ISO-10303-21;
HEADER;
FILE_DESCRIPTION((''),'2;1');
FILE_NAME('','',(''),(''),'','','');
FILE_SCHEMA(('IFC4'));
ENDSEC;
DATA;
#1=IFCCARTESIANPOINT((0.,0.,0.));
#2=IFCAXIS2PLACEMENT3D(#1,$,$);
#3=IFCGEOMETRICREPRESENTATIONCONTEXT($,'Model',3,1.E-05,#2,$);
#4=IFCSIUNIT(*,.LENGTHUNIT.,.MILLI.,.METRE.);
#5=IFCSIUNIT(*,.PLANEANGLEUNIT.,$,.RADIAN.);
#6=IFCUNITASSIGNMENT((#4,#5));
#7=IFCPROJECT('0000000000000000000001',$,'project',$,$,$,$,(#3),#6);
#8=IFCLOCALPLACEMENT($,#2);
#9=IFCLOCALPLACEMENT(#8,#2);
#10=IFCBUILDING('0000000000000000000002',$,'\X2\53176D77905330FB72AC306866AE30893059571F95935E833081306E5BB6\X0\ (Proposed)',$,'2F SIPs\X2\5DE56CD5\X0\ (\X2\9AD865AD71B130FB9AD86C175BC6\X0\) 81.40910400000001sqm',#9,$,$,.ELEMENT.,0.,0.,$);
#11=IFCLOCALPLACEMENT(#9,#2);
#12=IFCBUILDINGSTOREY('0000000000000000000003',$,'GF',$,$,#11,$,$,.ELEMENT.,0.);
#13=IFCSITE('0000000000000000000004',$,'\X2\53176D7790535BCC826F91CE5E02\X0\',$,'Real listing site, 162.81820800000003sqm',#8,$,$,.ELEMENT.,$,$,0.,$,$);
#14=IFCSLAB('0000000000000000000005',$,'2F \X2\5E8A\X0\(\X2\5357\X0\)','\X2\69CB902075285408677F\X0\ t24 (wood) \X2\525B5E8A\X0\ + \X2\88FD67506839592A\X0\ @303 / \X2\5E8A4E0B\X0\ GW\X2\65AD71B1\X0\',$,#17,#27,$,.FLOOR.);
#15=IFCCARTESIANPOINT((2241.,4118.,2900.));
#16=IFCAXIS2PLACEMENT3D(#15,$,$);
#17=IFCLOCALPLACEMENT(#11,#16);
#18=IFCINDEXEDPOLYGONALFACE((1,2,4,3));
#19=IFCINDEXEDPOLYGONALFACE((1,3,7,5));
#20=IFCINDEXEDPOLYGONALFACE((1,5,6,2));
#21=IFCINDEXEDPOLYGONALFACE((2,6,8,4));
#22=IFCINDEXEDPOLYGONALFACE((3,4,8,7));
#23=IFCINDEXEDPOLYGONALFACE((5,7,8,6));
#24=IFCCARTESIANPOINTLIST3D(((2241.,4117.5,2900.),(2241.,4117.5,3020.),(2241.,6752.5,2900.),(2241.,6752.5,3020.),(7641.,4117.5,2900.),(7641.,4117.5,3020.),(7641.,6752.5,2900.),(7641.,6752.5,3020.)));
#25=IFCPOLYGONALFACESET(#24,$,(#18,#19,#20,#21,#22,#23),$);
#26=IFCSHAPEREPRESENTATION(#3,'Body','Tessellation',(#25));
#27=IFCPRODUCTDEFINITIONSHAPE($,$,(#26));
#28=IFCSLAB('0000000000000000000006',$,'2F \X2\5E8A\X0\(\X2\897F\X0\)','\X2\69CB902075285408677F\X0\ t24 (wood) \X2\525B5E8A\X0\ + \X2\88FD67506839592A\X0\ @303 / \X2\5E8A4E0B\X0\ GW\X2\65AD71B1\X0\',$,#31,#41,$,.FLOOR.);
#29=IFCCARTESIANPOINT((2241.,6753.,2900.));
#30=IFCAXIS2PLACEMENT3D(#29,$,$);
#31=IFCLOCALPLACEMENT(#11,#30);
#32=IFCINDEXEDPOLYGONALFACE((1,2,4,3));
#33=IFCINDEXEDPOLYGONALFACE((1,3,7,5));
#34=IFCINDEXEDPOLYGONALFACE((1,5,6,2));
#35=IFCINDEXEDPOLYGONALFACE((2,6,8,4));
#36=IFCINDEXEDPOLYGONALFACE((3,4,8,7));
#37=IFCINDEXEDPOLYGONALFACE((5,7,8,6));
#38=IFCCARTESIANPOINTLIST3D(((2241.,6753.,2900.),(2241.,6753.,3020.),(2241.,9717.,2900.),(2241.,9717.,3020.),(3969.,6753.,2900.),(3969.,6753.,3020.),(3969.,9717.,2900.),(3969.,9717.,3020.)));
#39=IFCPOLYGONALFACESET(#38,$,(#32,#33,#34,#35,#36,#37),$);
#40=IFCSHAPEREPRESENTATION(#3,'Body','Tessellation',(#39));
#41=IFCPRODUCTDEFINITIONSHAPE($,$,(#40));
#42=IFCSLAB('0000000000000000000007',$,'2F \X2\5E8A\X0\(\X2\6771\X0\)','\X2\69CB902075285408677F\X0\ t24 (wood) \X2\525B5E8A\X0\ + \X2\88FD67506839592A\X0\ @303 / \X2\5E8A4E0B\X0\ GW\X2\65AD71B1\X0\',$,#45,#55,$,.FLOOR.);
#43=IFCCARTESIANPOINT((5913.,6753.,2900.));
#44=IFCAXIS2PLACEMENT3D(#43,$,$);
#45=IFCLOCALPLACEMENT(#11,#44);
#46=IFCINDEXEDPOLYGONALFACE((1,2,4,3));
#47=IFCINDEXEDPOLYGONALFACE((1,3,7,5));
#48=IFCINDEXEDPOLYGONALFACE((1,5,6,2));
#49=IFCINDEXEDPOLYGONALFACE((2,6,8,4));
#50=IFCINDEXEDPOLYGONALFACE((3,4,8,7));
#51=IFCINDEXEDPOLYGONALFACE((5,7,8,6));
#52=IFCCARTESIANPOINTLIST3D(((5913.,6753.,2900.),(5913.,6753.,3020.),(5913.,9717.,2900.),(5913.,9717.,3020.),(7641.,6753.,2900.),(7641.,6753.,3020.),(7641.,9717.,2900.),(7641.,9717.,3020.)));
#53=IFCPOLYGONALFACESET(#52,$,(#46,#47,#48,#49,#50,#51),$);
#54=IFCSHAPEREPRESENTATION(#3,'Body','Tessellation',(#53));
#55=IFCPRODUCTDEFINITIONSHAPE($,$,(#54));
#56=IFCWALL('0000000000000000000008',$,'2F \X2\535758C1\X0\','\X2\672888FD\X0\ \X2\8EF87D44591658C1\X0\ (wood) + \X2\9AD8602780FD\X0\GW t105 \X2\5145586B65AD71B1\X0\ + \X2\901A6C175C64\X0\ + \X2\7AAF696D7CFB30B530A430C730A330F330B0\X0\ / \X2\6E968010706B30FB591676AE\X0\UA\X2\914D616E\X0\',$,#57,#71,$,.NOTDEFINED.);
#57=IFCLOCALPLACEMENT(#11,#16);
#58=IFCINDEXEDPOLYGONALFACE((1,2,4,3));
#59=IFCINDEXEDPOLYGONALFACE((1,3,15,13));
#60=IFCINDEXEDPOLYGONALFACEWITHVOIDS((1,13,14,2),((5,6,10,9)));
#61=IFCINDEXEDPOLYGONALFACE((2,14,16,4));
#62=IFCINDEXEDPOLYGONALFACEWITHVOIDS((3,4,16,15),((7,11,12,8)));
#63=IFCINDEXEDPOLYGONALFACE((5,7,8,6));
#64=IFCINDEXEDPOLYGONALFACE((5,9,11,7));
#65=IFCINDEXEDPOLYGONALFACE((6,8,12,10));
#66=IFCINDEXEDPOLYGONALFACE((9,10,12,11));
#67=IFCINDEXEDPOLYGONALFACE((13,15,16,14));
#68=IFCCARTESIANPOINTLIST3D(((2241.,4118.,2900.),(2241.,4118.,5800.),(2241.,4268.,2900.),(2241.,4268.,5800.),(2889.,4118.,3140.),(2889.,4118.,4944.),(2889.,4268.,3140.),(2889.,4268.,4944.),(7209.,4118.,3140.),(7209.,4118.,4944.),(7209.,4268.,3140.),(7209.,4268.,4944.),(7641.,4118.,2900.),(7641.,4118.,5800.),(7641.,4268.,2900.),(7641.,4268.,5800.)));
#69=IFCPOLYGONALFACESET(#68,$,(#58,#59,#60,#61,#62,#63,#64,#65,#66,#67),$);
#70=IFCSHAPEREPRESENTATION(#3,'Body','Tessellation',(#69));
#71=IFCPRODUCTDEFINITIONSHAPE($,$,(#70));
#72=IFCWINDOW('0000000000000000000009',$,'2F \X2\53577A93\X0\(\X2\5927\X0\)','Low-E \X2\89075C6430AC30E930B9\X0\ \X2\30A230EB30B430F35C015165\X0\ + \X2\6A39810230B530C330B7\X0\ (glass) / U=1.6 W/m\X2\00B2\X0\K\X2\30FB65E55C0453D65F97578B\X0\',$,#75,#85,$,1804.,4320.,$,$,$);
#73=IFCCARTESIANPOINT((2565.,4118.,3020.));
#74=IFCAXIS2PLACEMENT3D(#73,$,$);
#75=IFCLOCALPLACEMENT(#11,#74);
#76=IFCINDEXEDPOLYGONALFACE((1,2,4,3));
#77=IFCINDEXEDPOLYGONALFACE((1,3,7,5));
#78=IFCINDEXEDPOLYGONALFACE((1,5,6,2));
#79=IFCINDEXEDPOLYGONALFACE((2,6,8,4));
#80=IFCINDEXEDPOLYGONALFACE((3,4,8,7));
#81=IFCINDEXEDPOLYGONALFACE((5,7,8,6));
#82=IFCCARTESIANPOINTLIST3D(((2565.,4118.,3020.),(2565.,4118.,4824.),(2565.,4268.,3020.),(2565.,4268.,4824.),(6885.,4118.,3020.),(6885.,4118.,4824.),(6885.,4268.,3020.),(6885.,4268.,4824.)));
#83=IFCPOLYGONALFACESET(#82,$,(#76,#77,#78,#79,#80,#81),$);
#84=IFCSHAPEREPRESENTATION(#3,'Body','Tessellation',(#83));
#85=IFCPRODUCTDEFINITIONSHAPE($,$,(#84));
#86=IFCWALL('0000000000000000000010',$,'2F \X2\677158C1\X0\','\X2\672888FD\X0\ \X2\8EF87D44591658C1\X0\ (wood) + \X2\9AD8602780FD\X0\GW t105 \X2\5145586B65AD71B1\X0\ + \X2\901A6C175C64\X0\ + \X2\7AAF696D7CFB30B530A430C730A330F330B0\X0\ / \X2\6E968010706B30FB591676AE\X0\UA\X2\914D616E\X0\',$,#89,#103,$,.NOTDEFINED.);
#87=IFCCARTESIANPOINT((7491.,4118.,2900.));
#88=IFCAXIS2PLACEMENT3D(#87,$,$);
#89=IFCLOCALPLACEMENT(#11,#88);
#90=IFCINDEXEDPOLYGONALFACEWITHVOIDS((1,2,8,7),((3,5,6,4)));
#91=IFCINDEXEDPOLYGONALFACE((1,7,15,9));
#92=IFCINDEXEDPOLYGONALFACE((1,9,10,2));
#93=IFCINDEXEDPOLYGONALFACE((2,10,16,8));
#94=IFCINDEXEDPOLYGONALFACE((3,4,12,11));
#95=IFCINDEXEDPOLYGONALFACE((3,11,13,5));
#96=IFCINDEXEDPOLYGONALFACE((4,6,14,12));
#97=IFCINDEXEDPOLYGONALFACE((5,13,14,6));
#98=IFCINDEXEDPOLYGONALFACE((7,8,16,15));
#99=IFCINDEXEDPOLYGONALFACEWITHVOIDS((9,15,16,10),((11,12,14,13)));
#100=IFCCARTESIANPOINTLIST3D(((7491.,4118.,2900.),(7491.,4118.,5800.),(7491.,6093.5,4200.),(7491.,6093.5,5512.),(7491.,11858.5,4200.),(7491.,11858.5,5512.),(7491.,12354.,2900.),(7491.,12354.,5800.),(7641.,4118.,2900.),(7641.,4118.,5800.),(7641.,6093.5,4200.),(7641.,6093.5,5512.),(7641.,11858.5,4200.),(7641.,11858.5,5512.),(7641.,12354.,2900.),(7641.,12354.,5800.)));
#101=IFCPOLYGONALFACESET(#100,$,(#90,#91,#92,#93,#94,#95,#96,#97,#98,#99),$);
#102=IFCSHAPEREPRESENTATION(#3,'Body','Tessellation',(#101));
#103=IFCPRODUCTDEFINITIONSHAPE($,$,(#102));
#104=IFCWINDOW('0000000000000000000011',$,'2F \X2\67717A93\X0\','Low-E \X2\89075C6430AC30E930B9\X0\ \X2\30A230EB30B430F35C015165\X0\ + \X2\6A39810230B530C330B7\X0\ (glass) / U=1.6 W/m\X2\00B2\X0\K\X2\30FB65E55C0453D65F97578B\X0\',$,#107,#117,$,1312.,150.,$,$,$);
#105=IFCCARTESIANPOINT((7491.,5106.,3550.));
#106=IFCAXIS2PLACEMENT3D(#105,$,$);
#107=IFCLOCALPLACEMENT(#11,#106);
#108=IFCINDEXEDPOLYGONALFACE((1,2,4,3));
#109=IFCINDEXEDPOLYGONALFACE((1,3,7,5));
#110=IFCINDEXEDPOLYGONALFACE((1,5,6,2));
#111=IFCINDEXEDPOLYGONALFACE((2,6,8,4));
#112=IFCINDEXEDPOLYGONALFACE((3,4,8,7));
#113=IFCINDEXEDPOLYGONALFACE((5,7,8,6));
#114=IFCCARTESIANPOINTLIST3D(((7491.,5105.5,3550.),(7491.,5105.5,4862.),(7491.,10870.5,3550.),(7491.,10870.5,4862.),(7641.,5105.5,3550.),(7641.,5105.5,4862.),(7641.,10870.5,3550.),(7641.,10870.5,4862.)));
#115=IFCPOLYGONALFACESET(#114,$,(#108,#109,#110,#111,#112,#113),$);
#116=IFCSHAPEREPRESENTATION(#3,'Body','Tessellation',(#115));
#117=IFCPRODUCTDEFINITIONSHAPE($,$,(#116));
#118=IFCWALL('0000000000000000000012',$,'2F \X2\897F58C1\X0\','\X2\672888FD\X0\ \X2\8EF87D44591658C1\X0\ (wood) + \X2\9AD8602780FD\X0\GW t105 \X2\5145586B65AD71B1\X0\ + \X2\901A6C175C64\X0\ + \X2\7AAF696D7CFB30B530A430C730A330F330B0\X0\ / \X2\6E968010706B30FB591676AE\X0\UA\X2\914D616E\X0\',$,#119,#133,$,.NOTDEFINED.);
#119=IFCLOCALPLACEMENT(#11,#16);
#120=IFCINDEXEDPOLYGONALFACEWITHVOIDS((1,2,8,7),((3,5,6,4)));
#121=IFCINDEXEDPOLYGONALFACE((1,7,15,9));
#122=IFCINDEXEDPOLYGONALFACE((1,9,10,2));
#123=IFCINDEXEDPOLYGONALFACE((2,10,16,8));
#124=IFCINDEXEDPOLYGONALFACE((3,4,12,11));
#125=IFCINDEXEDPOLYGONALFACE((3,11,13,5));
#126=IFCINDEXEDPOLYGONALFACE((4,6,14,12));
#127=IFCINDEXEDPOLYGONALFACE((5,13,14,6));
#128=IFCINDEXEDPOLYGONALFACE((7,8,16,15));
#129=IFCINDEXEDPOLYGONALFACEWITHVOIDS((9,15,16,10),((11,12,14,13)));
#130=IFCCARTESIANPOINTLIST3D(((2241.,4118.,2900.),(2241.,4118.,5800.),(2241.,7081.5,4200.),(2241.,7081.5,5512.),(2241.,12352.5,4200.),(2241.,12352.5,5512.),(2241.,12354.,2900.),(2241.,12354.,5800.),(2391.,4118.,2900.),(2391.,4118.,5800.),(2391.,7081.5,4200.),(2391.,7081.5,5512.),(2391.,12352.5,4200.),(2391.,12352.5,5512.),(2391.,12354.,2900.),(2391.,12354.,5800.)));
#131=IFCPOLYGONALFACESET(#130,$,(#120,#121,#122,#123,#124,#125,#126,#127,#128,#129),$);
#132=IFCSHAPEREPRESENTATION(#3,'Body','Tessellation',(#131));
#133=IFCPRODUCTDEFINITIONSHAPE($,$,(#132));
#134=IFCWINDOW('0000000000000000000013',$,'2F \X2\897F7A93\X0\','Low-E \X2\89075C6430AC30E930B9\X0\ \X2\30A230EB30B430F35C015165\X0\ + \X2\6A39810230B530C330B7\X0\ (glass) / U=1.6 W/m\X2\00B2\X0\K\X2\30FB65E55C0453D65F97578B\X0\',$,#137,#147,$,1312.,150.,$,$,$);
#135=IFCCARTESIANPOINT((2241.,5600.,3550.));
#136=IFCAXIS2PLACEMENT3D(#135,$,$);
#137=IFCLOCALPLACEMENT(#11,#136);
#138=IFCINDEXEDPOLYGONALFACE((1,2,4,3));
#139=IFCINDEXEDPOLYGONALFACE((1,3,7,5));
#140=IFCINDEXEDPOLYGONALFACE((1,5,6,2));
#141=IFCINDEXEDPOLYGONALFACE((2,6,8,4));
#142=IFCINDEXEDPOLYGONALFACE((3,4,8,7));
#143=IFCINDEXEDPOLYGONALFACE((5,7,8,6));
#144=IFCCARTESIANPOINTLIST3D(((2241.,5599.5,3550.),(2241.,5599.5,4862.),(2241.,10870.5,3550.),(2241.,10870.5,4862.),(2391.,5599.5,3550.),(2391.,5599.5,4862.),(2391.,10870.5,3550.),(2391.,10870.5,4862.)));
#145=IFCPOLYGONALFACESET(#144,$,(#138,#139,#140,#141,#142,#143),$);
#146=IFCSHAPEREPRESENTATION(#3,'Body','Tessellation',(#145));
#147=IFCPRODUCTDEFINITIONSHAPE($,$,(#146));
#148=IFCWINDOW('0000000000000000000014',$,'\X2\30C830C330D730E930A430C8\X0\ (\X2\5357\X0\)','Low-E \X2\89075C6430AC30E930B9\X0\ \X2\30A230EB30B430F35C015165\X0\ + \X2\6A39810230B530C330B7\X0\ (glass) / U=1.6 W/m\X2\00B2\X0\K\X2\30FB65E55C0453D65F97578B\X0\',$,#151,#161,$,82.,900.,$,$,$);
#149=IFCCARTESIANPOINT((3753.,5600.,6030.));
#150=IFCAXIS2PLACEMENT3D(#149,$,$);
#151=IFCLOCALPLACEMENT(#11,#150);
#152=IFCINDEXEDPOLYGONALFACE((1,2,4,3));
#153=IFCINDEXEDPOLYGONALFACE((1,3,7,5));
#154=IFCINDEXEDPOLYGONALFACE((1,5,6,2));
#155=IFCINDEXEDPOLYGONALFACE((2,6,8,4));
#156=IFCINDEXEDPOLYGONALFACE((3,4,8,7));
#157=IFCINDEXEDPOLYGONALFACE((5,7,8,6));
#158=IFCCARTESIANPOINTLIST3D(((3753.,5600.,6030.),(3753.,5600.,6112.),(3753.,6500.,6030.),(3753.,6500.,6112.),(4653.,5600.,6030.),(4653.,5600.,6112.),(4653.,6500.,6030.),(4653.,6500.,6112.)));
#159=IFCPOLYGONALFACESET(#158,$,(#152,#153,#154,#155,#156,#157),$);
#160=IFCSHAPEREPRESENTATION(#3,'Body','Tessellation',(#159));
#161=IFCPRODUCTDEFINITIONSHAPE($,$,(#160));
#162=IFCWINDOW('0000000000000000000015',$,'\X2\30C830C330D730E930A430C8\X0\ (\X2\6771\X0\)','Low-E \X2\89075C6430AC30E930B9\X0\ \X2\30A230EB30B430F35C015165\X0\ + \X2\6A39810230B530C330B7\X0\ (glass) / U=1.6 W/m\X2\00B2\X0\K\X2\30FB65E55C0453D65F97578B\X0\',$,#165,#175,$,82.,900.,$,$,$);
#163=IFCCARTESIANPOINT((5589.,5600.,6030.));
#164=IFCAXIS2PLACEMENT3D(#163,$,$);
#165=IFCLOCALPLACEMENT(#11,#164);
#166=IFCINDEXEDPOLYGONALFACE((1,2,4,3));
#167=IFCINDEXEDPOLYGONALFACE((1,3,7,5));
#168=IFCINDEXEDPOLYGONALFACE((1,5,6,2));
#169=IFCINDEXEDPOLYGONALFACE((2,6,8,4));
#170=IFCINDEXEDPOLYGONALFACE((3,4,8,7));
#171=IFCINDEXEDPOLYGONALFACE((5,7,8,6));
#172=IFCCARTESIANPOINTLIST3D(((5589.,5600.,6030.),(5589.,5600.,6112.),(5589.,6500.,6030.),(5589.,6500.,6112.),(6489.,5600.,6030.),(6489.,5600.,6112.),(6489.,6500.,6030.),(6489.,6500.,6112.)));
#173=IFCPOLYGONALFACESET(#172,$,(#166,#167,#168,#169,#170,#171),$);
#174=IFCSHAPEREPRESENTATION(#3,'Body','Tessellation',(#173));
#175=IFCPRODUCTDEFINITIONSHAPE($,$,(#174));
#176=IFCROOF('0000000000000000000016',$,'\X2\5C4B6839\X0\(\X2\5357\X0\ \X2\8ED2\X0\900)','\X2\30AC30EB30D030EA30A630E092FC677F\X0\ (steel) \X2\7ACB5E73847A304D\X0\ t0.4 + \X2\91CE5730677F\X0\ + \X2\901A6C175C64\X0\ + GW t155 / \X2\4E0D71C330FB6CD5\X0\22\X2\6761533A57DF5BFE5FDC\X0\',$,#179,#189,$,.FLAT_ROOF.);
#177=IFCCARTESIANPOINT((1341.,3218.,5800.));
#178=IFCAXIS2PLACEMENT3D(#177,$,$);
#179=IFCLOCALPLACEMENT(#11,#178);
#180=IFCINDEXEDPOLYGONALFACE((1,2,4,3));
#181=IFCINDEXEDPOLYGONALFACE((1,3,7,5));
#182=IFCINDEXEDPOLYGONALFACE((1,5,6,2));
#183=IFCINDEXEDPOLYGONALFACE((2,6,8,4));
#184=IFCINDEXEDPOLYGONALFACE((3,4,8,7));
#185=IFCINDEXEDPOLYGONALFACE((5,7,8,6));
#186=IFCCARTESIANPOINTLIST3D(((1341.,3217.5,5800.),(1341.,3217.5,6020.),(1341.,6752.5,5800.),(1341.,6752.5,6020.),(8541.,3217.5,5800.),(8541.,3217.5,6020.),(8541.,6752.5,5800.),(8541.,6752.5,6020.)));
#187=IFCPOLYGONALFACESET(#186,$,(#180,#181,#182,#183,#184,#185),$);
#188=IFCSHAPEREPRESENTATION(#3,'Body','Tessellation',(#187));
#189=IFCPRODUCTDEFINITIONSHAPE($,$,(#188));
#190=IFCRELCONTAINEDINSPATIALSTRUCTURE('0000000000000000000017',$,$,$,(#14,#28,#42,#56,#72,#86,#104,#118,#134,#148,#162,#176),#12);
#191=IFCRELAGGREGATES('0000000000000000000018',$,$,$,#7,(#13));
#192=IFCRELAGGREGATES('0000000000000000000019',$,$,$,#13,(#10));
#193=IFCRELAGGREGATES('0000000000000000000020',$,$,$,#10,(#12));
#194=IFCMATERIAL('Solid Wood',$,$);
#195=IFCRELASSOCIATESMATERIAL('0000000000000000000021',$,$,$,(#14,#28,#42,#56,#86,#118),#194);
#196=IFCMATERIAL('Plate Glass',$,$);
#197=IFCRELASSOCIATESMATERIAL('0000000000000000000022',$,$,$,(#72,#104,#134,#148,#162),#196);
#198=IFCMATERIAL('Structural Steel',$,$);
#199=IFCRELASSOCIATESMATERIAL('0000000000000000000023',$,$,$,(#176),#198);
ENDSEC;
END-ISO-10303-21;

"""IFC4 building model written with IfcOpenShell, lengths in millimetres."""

from ifc_helpers import new_model, si_unit, frame, frame_2d, origin, place, context, project, spatial, rectangle, extrude, material, element, fill, save


model = new_model("IFC4")

# Units and contexts
model_context = context("Model", 3, precision=1e-05, world=origin())
ifc_project = project(units=[si_unit("LENGTHUNIT", "METRE", prefix="MILLI"), si_unit("PLANEANGLEUNIT", "RADIAN")], contexts=[model_context])

# Site, building, storey
site_placement = place(None, origin())
site = spatial("IfcSite", under=ifc_project, at=site_placement, Name="北海道富良野市", ObjectType="Real listing site, 162.81820800000003sqm", CompositionType="ELEMENT", RefElevation=0.0)
building_placement = place(site_placement, origin())
building = spatial("IfcBuilding", under=site, at=building_placement, Name="北海道・犬と暮らす土間広めの家 (Proposed)", ObjectType="2F SIPs工法 (高断熱・高気密) 81.40910400000001sqm", CompositionType="ELEMENT", ElevationOfRefHeight=0.0, ElevationOfTerrain=0.0)
storey_placement = place(building_placement, origin())
storey = spatial("IfcBuildingStorey", under=building, at=storey_placement, Name="GF", CompositionType="ELEMENT", Elevation=0.0)

# Slabs
ifc_material_1 = material(Name="Solid Wood")
slab_1_placement = place(storey_placement, frame((2241.0, 4118.0, 2900.0)))
element("IfcSlab", 1, at=slab_1_placement, inside=storey, material=ifc_material_1, Name="2F 床(南)", Description="構造用合板 t24 (wood) 剛床 + 製材根太 @303 / 床下 GW断熱", PredefinedType="FLOOR", context=model_context, shape_type="SweptSolid", body=[
    extrude(rectangle(XDim=5400.0, YDim=2635.0, at=frame_2d((2700.0, 1317.0))), frame((2241.0, 4118.0, 2900.0)), (0.0, 0.0, 1.0), 120.0),
])
slab_2_placement = place(storey_placement, frame((2241.0, 6753.0, 2900.0)))
element("IfcSlab", 2, at=slab_2_placement, inside=storey, material=ifc_material_1, Name="2F 床(西)", Description="構造用合板 t24 (wood) 剛床 + 製材根太 @303 / 床下 GW断熱", PredefinedType="FLOOR", context=model_context, shape_type="SweptSolid", body=[
    extrude(rectangle(XDim=1728.0, YDim=2964.0, at=frame_2d((864.0, 1482.0))), frame((2241.0, 6753.0, 2900.0)), (0.0, 0.0, 1.0), 120.0),
])
slab_3_placement = place(storey_placement, frame((5913.0, 6753.0, 2900.0)))
element("IfcSlab", 3, at=slab_3_placement, inside=storey, material=ifc_material_1, Name="2F 床(東)", Description="構造用合板 t24 (wood) 剛床 + 製材根太 @303 / 床下 GW断熱", PredefinedType="FLOOR", context=model_context, shape_type="SweptSolid", body=[
    extrude(rectangle(XDim=1728.0, YDim=2964.0, at=frame_2d((864.0, 1482.0))), frame((5913.0, 6753.0, 2900.0)), (0.0, 0.0, 1.0), 120.0),
])

# Walls, openings, windows
wall_1_placement = place(storey_placement, frame((2241.0, 4118.0, 2900.0)))
wall_1 = element("IfcWall", 4, at=wall_1_placement, inside=storey, material=ifc_material_1, Name="2F 南壁", Description="木製 軸組外壁 (wood) + 高性能GW t105 充填断熱 + 通気層 + 窯業系サイディング / 準耐火・外皮UA配慮", PredefinedType="NOTDEFINED", context=model_context, shape_type="SweptSolid", body=[
    extrude(rectangle(XDim=5400.0, YDim=150.0, at=frame_2d((2700.0, 75.0))), frame((2241.0, 4118.0, 2900.0)), (0.0, 0.0, 1.0), 2900.0),
])
opening_1_placement = place(storey_placement, frame((2565.0, 4118.0, 3020.0)))
opening_1 = element("IfcOpeningElement", 5, at=opening_1_placement, cuts=wall_1, PredefinedType="NOTDEFINED", context=model_context, shape_type="SweptSolid", body=[
    extrude(rectangle(XDim=4320.0, YDim=150.0, at=frame_2d((2160.0, 75.0))), frame((2565.0, 4118.0, 3020.0)), (0.0, 0.0, 1.0), 1804.0),
])
ifc_material_2 = material(Name="Plate Glass")
window_1_placement = place(storey_placement, frame((2565.0, 4118.0, 3020.0)))
window_1 = element("IfcWindow", 6, at=window_1_placement, inside=storey, material=ifc_material_2, Name="2F 南窓(大)", Description="Low-E 複層ガラス アルゴン封入 + 樹脂サッシ (glass) / U=1.6 W/m²K・日射取得型", OverallHeight=1804.0, OverallWidth=4320.0, context=model_context, shape_type="SweptSolid", body=[
    extrude(rectangle(XDim=4320.0, YDim=150.0, at=frame_2d((2160.0, 75.0))), frame((2565.0, 4118.0, 3020.0)), (0.0, 0.0, 1.0), 1804.0),
])
fill(opening_1, window_1)
wall_2_placement = place(storey_placement, frame((7491.0, 4118.0, 2900.0)))
wall_2 = element("IfcWall", 7, at=wall_2_placement, inside=storey, material=ifc_material_1, Name="2F 東壁", Description="木製 軸組外壁 (wood) + 高性能GW t105 充填断熱 + 通気層 + 窯業系サイディング / 準耐火・外皮UA配慮", PredefinedType="NOTDEFINED", context=model_context, shape_type="SweptSolid", body=[
    extrude(rectangle(XDim=150.0, YDim=8236.0, at=frame_2d((75.0, 4118.0))), frame((7491.0, 4118.0, 2900.0)), (0.0, 0.0, 1.0), 2900.0),
])
opening_2_placement = place(storey_placement, frame((7491.0, 5106.0, 3550.0)))
opening_2 = element("IfcOpeningElement", 8, at=opening_2_placement, cuts=wall_2, PredefinedType="NOTDEFINED", context=model_context, shape_type="SweptSolid", body=[
    extrude(rectangle(XDim=150.0, YDim=5765.0, at=frame_2d((75.0, 2882.0))), frame((7491.0, 5106.0, 3550.0)), (0.0, 0.0, 1.0), 1312.0),
])
window_2_placement = place(storey_placement, frame((7491.0, 5106.0, 3550.0)))
window_2 = element("IfcWindow", 9, at=window_2_placement, inside=storey, material=ifc_material_2, Name="2F 東窓", Description="Low-E 複層ガラス アルゴン封入 + 樹脂サッシ (glass) / U=1.6 W/m²K・日射取得型", OverallHeight=1312.0, OverallWidth=150.0, context=model_context, shape_type="SweptSolid", body=[
    extrude(rectangle(XDim=150.0, YDim=5765.0, at=frame_2d((75.0, 2882.0))), frame((7491.0, 5106.0, 3550.0)), (0.0, 0.0, 1.0), 1312.0),
])
fill(opening_2, window_2)
wall_3_placement = place(storey_placement, frame((2241.0, 4118.0, 2900.0)))
wall_3 = element("IfcWall", 10, at=wall_3_placement, inside=storey, material=ifc_material_1, Name="2F 西壁", Description="木製 軸組外壁 (wood) + 高性能GW t105 充填断熱 + 通気層 + 窯業系サイディング / 準耐火・外皮UA配慮", PredefinedType="NOTDEFINED", context=model_context, shape_type="SweptSolid", body=[
    extrude(rectangle(XDim=150.0, YDim=8236.0, at=frame_2d((75.0, 4118.0))), frame((2241.0, 4118.0, 2900.0)), (0.0, 0.0, 1.0), 2900.0),
])
opening_3_placement = place(storey_placement, frame((2241.0, 5600.0, 3550.0)))
opening_3 = element("IfcOpeningElement", 11, at=opening_3_placement, cuts=wall_3, PredefinedType="NOTDEFINED", context=model_context, shape_type="SweptSolid", body=[
    extrude(rectangle(XDim=150.0, YDim=5271.0, at=frame_2d((75.0, 2635.0))), frame((2241.0, 5600.0, 3550.0)), (0.0, 0.0, 1.0), 1312.0),
])
window_3_placement = place(storey_placement, frame((2241.0, 5600.0, 3550.0)))
window_3 = element("IfcWindow", 12, at=window_3_placement, inside=storey, material=ifc_material_2, Name="2F 西窓", Description="Low-E 複層ガラス アルゴン封入 + 樹脂サッシ (glass) / U=1.6 W/m²K・日射取得型", OverallHeight=1312.0, OverallWidth=150.0, context=model_context, shape_type="SweptSolid", body=[
    extrude(rectangle(XDim=150.0, YDim=5271.0, at=frame_2d((75.0, 2635.0))), frame((2241.0, 5600.0, 3550.0)), (0.0, 0.0, 1.0), 1312.0),
])
fill(opening_3, window_3)

# Windows
window_4_placement = place(storey_placement, frame((3753.0, 5600.0, 6030.0)))
element("IfcWindow", 13, at=window_4_placement, inside=storey, material=ifc_material_2, Name="トップライト (南)", Description="Low-E 複層ガラス アルゴン封入 + 樹脂サッシ (glass) / U=1.6 W/m²K・日射取得型", OverallHeight=82.0, OverallWidth=900.0, context=model_context, shape_type="SweptSolid", body=[
    extrude(rectangle(XDim=900.0, YDim=900.0, at=frame_2d((450.0, 450.0))), frame((3753.0, 5600.0, 6030.0)), (0.0, 0.0, 1.0), 82.0),
])
window_5_placement = place(storey_placement, frame((5589.0, 5600.0, 6030.0)))
element("IfcWindow", 14, at=window_5_placement, inside=storey, material=ifc_material_2, Name="トップライト (東)", Description="Low-E 複層ガラス アルゴン封入 + 樹脂サッシ (glass) / U=1.6 W/m²K・日射取得型", OverallHeight=82.0, OverallWidth=900.0, context=model_context, shape_type="SweptSolid", body=[
    extrude(rectangle(XDim=900.0, YDim=900.0, at=frame_2d((450.0, 450.0))), frame((5589.0, 5600.0, 6030.0)), (0.0, 0.0, 1.0), 82.0),
])

# Roof
ifc_material_3 = material(Name="Structural Steel")
roof_1_placement = place(storey_placement, frame((1341.0, 3218.0, 5800.0)))
element("IfcRoof", 15, at=roof_1_placement, inside=storey, material=ifc_material_3, Name="屋根(南 軒900)", Description="ガルバリウム鋼板 (steel) 立平葺き t0.4 + 野地板 + 通気層 + GW t155 / 不燃・法22条区域対応", PredefinedType="FLAT_ROOF", context=model_context, shape_type="SweptSolid", body=[
    extrude(rectangle(XDim=7200.0, YDim=3535.0, at=frame_2d((3600.0, 1767.0))), frame((1341.0, 3218.0, 5800.0)), (0.0, 0.0, 1.0), 220.0),
])

save(model, "model.ifc")
